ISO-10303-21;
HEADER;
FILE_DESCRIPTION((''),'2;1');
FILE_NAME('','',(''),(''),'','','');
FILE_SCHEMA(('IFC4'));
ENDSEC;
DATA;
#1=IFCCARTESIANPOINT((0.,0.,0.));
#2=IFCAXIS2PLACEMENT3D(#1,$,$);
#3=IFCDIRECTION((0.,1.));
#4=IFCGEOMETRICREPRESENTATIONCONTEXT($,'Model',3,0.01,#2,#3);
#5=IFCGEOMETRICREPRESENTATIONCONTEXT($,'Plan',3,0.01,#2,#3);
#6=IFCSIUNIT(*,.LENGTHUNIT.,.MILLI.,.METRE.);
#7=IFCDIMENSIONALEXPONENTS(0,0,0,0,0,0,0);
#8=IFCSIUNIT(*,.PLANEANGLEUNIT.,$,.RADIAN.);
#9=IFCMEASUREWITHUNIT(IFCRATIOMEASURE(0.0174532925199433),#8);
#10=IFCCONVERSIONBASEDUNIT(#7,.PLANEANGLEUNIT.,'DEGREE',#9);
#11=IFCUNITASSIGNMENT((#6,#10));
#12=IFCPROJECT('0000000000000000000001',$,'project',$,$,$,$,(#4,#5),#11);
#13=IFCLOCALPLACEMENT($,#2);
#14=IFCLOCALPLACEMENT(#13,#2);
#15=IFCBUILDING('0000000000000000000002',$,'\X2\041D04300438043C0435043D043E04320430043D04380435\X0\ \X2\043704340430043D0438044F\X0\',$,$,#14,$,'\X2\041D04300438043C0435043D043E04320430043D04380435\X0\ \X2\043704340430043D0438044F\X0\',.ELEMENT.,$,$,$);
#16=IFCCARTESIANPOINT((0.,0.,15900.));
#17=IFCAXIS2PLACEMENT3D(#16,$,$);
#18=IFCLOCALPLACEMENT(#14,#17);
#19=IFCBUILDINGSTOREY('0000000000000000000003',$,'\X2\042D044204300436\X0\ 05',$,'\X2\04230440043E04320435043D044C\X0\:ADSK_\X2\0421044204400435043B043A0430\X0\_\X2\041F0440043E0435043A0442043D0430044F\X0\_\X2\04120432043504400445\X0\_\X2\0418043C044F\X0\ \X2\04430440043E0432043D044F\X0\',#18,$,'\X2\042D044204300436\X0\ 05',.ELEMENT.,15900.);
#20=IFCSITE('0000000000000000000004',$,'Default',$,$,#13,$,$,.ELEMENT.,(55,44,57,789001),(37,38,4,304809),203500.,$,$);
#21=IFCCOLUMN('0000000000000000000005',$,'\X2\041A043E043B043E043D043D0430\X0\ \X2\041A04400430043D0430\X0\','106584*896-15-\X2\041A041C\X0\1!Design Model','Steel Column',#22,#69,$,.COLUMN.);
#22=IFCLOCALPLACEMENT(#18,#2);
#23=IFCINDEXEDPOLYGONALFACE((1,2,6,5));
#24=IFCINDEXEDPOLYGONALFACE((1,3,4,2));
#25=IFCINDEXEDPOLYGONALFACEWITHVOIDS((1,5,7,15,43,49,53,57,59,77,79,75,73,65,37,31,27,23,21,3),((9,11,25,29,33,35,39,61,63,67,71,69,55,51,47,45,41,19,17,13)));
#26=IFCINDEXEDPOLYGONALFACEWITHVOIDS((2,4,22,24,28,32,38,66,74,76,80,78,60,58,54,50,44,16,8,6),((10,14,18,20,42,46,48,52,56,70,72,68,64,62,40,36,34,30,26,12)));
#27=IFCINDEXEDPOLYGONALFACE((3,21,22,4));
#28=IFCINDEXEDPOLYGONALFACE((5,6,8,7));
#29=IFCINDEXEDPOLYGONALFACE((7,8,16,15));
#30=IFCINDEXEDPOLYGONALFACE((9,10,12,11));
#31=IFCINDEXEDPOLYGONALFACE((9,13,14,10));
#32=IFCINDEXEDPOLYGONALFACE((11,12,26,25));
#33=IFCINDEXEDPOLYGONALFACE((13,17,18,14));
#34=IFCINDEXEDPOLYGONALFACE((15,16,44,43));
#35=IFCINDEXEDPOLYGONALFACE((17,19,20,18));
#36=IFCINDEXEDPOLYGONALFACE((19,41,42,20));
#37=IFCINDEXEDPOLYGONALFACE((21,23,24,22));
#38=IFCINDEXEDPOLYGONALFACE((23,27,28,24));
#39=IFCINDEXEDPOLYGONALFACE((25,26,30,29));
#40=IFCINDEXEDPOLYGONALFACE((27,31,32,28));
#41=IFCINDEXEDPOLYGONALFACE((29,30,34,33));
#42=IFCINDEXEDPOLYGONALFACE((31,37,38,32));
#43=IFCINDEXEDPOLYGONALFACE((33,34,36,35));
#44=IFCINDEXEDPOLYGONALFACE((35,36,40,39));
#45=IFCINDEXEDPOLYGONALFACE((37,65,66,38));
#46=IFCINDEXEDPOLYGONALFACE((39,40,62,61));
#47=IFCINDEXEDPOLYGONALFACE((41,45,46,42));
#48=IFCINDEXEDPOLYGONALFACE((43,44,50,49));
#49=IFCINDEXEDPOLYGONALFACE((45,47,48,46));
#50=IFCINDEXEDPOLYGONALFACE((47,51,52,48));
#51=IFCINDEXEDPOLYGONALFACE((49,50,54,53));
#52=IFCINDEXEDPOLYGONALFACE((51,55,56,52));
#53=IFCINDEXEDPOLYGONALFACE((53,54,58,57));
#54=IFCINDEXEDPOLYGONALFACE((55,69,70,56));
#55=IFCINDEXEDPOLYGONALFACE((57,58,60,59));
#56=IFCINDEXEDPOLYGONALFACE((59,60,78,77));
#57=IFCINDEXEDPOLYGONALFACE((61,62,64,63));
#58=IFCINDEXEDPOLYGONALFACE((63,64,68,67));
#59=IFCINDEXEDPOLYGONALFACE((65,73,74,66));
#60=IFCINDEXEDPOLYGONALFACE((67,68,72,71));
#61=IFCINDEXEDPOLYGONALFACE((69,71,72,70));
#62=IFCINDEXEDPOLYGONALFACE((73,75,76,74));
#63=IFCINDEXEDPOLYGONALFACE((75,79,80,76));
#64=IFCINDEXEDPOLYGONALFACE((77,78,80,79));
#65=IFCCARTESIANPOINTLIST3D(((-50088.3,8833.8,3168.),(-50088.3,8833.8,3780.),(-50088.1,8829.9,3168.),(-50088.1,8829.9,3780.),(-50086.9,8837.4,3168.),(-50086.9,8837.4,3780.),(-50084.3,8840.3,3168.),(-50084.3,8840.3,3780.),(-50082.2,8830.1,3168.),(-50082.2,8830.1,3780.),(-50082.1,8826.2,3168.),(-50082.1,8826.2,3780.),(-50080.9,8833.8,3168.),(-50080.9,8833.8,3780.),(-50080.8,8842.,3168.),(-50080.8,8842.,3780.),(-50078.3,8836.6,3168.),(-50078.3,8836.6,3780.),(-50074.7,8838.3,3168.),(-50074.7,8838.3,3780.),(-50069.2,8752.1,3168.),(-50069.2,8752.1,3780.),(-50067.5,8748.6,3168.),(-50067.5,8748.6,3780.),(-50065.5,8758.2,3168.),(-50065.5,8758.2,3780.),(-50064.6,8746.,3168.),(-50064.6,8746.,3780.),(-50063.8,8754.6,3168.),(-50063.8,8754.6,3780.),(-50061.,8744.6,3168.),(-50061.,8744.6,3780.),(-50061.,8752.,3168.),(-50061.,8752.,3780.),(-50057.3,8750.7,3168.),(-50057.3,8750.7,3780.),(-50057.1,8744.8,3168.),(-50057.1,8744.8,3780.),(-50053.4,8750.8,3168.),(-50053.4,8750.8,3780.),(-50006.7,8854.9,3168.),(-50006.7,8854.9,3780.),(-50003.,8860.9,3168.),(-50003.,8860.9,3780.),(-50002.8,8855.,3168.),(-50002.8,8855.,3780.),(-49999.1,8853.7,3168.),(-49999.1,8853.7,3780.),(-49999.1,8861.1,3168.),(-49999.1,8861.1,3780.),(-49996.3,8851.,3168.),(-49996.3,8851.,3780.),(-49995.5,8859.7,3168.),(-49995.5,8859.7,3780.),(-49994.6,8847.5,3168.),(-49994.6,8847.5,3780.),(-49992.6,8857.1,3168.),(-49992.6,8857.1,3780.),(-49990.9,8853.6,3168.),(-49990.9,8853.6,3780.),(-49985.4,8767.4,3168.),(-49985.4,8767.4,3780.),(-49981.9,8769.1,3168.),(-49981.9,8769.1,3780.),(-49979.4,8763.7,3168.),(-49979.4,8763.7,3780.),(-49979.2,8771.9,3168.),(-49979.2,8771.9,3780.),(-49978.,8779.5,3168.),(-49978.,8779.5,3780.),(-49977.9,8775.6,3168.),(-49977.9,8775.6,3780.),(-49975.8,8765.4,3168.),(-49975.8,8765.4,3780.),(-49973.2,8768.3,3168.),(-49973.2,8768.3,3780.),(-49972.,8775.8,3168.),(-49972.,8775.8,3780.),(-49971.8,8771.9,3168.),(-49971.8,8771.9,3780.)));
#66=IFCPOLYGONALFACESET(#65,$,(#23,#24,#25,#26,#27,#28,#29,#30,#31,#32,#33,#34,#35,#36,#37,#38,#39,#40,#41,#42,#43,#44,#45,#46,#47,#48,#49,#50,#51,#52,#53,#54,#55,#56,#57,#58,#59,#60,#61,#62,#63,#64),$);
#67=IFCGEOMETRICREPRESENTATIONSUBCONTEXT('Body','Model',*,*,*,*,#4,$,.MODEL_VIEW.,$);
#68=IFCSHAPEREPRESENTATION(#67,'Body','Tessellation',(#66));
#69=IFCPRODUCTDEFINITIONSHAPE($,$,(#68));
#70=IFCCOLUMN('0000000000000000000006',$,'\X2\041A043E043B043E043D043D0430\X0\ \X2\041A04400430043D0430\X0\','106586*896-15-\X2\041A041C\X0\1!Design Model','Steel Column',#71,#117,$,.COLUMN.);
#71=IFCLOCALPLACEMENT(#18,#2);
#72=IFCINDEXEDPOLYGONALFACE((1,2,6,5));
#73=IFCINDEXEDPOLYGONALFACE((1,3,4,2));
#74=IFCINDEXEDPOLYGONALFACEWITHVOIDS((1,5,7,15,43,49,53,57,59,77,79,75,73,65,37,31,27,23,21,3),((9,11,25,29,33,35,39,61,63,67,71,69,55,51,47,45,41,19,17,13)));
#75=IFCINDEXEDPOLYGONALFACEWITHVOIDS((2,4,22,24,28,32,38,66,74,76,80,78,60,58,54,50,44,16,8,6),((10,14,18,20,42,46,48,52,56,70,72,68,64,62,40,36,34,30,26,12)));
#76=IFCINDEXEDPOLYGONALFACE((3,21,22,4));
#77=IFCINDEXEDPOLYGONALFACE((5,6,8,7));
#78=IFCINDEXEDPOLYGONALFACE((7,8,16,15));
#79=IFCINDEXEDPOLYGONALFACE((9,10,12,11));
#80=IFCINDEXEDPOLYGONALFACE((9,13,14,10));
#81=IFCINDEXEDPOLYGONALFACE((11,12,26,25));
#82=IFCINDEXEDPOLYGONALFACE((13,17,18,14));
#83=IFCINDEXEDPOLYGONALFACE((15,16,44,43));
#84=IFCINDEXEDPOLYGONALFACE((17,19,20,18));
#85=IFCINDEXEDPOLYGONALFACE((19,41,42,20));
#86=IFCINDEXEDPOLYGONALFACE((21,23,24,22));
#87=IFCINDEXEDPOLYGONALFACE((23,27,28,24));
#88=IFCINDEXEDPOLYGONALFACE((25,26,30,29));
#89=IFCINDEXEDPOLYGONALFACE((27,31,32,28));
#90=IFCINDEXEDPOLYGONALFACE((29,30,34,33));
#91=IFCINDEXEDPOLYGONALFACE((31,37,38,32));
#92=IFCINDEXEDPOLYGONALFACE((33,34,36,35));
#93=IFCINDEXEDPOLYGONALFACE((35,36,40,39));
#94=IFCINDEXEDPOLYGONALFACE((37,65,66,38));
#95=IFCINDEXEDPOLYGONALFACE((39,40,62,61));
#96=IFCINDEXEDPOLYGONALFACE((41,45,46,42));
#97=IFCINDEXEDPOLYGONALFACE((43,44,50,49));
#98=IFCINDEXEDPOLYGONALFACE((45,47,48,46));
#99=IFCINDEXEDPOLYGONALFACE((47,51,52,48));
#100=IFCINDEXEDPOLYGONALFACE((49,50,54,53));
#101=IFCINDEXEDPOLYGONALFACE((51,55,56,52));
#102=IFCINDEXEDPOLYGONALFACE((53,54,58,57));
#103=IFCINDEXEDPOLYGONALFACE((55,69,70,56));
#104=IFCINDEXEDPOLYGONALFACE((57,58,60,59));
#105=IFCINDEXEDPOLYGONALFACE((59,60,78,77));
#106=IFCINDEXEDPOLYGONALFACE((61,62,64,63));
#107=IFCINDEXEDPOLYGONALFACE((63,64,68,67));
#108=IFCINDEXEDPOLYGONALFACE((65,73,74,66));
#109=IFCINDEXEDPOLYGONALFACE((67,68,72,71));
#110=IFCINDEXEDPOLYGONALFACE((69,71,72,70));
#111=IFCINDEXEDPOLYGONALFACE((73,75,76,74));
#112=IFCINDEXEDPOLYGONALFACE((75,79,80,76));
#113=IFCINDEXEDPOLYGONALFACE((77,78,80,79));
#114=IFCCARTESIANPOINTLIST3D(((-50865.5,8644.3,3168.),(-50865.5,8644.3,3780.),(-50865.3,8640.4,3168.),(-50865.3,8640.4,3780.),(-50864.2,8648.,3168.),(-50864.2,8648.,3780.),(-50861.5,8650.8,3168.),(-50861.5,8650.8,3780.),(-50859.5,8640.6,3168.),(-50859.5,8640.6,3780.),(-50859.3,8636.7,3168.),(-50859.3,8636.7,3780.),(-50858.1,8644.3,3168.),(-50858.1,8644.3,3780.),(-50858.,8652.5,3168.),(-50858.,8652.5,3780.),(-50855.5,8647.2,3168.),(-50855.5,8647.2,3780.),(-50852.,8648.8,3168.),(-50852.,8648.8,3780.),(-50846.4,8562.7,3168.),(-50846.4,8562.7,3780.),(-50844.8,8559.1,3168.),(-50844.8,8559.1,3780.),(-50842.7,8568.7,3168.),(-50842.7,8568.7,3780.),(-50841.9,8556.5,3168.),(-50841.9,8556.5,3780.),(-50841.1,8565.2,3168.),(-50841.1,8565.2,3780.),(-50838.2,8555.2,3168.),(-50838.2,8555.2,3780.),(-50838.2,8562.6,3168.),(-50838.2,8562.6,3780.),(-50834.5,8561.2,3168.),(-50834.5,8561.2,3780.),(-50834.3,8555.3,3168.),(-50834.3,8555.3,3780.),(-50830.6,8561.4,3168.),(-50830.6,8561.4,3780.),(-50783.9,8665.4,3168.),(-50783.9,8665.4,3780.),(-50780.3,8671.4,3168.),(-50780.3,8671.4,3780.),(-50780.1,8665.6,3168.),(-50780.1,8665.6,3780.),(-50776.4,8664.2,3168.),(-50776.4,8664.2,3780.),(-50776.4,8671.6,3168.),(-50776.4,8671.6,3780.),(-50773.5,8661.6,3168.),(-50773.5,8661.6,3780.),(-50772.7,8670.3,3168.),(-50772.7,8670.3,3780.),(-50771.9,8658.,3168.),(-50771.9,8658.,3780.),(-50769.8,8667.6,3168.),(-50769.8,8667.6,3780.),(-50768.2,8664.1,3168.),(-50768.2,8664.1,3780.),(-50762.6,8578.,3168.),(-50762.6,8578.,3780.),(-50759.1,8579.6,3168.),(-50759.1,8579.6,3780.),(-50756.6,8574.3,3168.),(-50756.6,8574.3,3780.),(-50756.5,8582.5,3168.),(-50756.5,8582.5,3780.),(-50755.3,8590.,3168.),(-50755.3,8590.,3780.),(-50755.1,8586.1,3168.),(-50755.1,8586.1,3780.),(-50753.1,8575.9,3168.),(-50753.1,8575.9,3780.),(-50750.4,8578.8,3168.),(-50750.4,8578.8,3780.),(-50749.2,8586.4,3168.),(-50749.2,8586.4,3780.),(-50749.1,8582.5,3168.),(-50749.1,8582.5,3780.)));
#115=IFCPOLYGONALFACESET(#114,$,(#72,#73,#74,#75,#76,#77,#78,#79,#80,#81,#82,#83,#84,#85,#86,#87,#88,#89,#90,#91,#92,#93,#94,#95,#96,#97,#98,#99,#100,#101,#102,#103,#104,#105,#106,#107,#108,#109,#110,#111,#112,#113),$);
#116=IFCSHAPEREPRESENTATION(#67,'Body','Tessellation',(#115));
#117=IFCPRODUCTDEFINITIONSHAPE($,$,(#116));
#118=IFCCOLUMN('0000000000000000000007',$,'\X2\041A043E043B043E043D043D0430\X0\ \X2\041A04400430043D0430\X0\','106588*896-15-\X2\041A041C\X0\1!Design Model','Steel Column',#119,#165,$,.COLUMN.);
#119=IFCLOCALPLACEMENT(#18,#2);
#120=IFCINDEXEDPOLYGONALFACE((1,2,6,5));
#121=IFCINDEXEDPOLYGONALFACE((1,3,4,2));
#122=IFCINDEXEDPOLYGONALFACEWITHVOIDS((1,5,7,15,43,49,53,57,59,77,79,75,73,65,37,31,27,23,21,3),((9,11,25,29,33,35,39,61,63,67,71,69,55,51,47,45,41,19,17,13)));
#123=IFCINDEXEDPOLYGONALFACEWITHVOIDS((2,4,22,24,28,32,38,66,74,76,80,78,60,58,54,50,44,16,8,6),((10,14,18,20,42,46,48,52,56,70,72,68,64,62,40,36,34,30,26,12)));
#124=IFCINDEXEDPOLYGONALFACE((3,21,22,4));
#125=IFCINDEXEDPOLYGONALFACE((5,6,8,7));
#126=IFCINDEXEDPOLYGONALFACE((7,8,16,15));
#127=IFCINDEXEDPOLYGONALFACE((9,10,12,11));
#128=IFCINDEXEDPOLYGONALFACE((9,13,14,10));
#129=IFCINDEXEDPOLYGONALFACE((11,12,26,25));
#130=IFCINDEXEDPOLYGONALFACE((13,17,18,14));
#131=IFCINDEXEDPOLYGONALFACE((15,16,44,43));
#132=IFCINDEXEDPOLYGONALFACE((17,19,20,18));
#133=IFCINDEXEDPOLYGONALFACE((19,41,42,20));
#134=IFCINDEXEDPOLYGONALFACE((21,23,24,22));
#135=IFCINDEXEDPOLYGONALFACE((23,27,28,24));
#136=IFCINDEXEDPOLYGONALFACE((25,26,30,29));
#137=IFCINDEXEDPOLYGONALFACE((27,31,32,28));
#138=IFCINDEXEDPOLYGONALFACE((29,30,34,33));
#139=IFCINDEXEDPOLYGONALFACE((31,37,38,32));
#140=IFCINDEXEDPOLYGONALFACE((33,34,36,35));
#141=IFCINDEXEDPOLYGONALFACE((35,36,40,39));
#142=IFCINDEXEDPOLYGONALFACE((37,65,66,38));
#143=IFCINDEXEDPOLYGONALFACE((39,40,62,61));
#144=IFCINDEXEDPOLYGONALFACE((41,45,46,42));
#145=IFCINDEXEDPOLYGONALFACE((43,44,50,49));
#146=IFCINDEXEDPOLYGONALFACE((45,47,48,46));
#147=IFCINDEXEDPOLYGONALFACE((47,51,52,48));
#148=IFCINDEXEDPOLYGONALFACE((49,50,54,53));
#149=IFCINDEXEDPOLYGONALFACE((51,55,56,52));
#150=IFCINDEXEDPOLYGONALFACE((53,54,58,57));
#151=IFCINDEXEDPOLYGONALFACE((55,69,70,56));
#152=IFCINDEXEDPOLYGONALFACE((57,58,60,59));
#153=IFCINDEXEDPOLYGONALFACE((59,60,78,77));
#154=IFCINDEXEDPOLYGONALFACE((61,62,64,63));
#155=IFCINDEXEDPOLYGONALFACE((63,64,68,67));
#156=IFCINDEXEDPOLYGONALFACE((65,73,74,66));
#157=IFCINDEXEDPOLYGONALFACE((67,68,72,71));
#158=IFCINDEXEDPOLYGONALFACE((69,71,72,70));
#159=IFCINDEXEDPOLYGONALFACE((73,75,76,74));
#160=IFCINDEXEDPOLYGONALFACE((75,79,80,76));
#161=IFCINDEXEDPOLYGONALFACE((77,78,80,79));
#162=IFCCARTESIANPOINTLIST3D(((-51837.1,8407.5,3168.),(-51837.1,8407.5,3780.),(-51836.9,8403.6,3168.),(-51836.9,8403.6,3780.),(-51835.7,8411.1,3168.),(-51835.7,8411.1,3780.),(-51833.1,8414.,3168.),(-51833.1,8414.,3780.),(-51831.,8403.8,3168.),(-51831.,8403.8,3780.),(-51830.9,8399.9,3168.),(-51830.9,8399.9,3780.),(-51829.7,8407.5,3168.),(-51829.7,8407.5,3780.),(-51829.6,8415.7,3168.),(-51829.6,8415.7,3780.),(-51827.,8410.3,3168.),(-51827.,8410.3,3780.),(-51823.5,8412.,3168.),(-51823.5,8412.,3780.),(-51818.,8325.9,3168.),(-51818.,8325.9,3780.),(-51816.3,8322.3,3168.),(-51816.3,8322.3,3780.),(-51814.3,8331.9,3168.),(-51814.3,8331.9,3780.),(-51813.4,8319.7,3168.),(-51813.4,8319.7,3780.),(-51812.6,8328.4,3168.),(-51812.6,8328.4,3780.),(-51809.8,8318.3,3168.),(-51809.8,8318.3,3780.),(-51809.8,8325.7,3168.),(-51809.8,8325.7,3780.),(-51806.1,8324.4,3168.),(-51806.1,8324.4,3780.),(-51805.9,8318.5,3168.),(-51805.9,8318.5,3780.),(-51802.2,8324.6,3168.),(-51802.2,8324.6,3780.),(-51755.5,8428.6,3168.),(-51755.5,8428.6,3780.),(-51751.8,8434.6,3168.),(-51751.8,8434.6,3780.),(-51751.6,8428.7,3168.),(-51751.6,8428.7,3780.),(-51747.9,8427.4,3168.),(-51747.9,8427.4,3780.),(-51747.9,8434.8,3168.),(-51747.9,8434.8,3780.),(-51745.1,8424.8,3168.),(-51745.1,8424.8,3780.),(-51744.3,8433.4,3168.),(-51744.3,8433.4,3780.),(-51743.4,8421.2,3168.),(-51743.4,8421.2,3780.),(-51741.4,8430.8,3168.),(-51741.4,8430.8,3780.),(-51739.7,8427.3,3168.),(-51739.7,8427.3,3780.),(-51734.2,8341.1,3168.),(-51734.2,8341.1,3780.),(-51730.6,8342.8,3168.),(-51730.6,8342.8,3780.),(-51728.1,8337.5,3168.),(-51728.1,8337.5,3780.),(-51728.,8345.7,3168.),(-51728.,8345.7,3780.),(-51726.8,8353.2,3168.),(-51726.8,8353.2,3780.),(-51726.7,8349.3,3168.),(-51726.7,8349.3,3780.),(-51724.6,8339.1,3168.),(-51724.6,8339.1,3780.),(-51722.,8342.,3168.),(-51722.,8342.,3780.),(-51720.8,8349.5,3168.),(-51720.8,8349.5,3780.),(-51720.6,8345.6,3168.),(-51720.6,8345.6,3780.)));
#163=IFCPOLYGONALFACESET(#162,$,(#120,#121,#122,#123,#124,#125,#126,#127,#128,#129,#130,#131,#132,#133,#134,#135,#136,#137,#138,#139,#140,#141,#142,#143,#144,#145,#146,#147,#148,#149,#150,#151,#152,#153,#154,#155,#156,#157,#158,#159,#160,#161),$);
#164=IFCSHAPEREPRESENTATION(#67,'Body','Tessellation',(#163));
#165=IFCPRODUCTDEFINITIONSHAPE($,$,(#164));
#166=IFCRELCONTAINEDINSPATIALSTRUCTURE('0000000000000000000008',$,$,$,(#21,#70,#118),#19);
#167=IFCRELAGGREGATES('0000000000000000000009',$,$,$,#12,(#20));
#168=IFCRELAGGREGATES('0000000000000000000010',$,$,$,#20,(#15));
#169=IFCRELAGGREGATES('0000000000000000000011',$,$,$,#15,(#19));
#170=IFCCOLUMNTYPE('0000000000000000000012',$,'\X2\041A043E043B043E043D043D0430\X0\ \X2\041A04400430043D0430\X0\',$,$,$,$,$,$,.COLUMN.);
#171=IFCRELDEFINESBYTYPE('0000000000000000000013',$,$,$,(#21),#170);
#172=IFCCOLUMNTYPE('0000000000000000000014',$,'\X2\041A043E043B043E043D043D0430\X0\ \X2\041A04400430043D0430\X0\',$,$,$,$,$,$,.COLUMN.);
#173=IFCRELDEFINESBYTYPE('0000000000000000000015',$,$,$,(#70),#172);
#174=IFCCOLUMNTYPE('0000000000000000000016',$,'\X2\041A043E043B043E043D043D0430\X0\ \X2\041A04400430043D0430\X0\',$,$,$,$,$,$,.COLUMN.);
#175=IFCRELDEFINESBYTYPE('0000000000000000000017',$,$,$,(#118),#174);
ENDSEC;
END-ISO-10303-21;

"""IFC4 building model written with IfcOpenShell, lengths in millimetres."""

from ifc_helpers import new_model, entity, si_unit, converted_unit, direction, frame, origin, place, context, subcontext, project, spatial, indexed_curve, outline, extrude, type_object, element, save


model = new_model("IFC4")

# Units and contexts
model_context = context("Model", 3, precision=0.01, world=origin(), true_north=direction((0.0, 1.0)))
plan_context = context("Plan", 3, precision=0.01, world=origin(), true_north=direction((0.0, 1.0)))
body_context = subcontext(model_context, "Body", "Model", "MODEL_VIEW")
ifc_project = project(units=[si_unit("LENGTHUNIT", "METRE", prefix="MILLI"), converted_unit("PLANEANGLEUNIT", "DEGREE", entity("IfcRatioMeasure", 0.0174532925199433), si_unit("PLANEANGLEUNIT", "RADIAN"), dimensions=[0, 0, 0, 0, 0, 0, 0])], contexts=[model_context, plan_context])

# Site, building, storey
site_placement = place(None, origin())
site = spatial("IfcSite", under=ifc_project, at=site_placement, Name="Default", CompositionType="ELEMENT", RefLatitude=(55, 44, 57, 789001), RefLongitude=(37, 38, 4, 304809), RefElevation=203500.0)
building_placement = place(site_placement, origin())
building = spatial("IfcBuilding", under=site, at=building_placement, Name="Наименование здания", LongName="Наименование здания", CompositionType="ELEMENT")
storey_placement = place(building_placement, frame((0.0, 0.0, 15900.0)))
storey = spatial("IfcBuildingStorey", under=building, at=storey_placement, Name="Этаж 05", ObjectType="Уровень:ADSK_Стрелка_Проектная_Вверх_Имя уровня", LongName="Этаж 05", CompositionType="ELEMENT", Elevation=15900.0)

# Columns
column_type_1 = type_object("IfcColumnType", Name="Колонна Крана", PredefinedType="COLUMN")
column_1_placement = place(storey_placement, origin())
element("IfcColumn", 1, at=column_1_placement, inside=storey, type_object=column_type_1, Name="Колонна Крана", Description="106584*896-15-КМ1!Design Model", ObjectType="Steel Column", PredefinedType="COLUMN", context=body_context, shape_type="SweptSolid", body=[
    extrude(outline(indexed_curve([(29.5, -56.8), (33.4, -56.8), (37.0, -55.3), (39.7, -52.6), (41.2, -49.0), (56.8, 29.5), (56.8, 33.4), (55.3, 37.0), (52.6, 39.7), (49.0, 41.2), (-29.5, 56.8), (-33.4, 56.8), (-37.0, 55.3), (-39.7, 52.6), (-41.2, 49.0), (-56.8, -29.5), (-56.8, -33.4), (-55.3, -37.0), (-52.6, -39.7), (-49.0, -41.2), (29.5, -56.8)], self_intersect=False), holes=[indexed_curve([(-43.1, -37.3), (-46.7, -35.8), (-49.5, -33.1), (-51.0, -29.5), (-51.0, -25.5), (-37.3, 43.1), (-35.8, 46.7), (-33.1, 49.5), (-29.5, 51.0), (-25.5, 51.0), (43.1, 37.3), (46.7, 35.8), (49.5, 33.1), (51.0, 29.5), (51.0, 25.5), (37.3, -43.1), (35.8, -46.7), (33.1, -49.5), (29.5, -51.0), (25.5, -51.0), (-43.1, -37.3)], self_intersect=False)]), frame((-50030.1, 8802.8, 3168.0), z_axis=(0.0, 0.0, 1.0), x_axis=(0.906681, 0.421816, 0.0)), (0.0, 0.0, 1.0), 612.0),
])
column_type_2 = type_object("IfcColumnType", Name="Колонна Крана", PredefinedType="COLUMN")
column_2_placement = place(storey_placement, origin())
element("IfcColumn", 2, at=column_2_placement, inside=storey, type_object=column_type_2, Name="Колонна Крана", Description="106586*896-15-КМ1!Design Model", ObjectType="Steel Column", PredefinedType="COLUMN", context=body_context, shape_type="SweptSolid", body=[
    extrude(outline(indexed_curve([(29.5, -56.8), (33.4, -56.8), (37.0, -55.3), (39.7, -52.6), (41.2, -49.0), (56.8, 29.5), (56.8, 33.4), (55.3, 37.0), (52.6, 39.7), (49.0, 41.2), (-29.5, 56.8), (-33.4, 56.8), (-37.0, 55.3), (-39.7, 52.6), (-41.2, 49.0), (-56.8, -29.5), (-56.8, -33.4), (-55.3, -37.0), (-52.6, -39.7), (-49.0, -41.2), (29.5, -56.8)], self_intersect=False), holes=[indexed_curve([(-43.1, -37.3), (-46.7, -35.8), (-49.5, -33.1), (-51.0, -29.5), (-51.0, -25.5), (-37.3, 43.1), (-35.8, 46.7), (-33.1, 49.5), (-29.5, 51.0), (-25.5, 51.0), (43.1, 37.3), (46.7, 35.8), (49.5, 33.1), (51.0, 29.5), (51.0, 25.5), (37.3, -43.1), (35.8, -46.7), (33.1, -49.5), (29.5, -51.0), (25.5, -51.0), (-43.1, -37.3)], self_intersect=False)]), frame((-50807.3, 8613.4, 3168.0), z_axis=(0.0, 0.0, 1.0), x_axis=(0.906681, 0.421816, 0.0)), (0.0, 0.0, 1.0), 612.0),
])
column_type_3 = type_object("IfcColumnType", Name="Колонна Крана", PredefinedType="COLUMN")
column_3_placement = place(storey_placement, origin())
element("IfcColumn", 3, at=column_3_placement, inside=storey, type_object=column_type_3, Name="Колонна Крана", Description="106588*896-15-КМ1!Design Model", ObjectType="Steel Column", PredefinedType="COLUMN", context=body_context, shape_type="SweptSolid", body=[
    extrude(outline(indexed_curve([(29.5, -56.8), (33.4, -56.8), (37.0, -55.3), (39.7, -52.6), (41.2, -49.0), (56.8, 29.5), (56.8, 33.4), (55.3, 37.0), (52.6, 39.7), (49.0, 41.2), (-29.5, 56.8), (-33.4, 56.8), (-37.0, 55.3), (-39.7, 52.6), (-41.2, 49.0), (-56.8, -29.5), (-56.8, -33.4), (-55.3, -37.0), (-52.6, -39.7), (-49.0, -41.2), (29.5, -56.8)], self_intersect=False), holes=[indexed_curve([(-43.1, -37.3), (-46.7, -35.8), (-49.5, -33.1), (-51.0, -29.5), (-51.0, -25.5), (-37.3, 43.1), (-35.8, 46.7), (-33.1, 49.5), (-29.5, 51.0), (-25.5, 51.0), (43.1, 37.3), (46.7, 35.8), (49.5, 33.1), (51.0, 29.5), (51.0, 25.5), (37.3, -43.1), (35.8, -46.7), (33.1, -49.5), (29.5, -51.0), (25.5, -51.0), (-43.1, -37.3)], self_intersect=False)]), frame((-51778.8, 8376.6, 3168.0), z_axis=(0.0, 0.0, 1.0), x_axis=(0.906681, 0.421816, 0.0)), (0.0, 0.0, 1.0), 612.0),
])

save(model, "model.ifc")
